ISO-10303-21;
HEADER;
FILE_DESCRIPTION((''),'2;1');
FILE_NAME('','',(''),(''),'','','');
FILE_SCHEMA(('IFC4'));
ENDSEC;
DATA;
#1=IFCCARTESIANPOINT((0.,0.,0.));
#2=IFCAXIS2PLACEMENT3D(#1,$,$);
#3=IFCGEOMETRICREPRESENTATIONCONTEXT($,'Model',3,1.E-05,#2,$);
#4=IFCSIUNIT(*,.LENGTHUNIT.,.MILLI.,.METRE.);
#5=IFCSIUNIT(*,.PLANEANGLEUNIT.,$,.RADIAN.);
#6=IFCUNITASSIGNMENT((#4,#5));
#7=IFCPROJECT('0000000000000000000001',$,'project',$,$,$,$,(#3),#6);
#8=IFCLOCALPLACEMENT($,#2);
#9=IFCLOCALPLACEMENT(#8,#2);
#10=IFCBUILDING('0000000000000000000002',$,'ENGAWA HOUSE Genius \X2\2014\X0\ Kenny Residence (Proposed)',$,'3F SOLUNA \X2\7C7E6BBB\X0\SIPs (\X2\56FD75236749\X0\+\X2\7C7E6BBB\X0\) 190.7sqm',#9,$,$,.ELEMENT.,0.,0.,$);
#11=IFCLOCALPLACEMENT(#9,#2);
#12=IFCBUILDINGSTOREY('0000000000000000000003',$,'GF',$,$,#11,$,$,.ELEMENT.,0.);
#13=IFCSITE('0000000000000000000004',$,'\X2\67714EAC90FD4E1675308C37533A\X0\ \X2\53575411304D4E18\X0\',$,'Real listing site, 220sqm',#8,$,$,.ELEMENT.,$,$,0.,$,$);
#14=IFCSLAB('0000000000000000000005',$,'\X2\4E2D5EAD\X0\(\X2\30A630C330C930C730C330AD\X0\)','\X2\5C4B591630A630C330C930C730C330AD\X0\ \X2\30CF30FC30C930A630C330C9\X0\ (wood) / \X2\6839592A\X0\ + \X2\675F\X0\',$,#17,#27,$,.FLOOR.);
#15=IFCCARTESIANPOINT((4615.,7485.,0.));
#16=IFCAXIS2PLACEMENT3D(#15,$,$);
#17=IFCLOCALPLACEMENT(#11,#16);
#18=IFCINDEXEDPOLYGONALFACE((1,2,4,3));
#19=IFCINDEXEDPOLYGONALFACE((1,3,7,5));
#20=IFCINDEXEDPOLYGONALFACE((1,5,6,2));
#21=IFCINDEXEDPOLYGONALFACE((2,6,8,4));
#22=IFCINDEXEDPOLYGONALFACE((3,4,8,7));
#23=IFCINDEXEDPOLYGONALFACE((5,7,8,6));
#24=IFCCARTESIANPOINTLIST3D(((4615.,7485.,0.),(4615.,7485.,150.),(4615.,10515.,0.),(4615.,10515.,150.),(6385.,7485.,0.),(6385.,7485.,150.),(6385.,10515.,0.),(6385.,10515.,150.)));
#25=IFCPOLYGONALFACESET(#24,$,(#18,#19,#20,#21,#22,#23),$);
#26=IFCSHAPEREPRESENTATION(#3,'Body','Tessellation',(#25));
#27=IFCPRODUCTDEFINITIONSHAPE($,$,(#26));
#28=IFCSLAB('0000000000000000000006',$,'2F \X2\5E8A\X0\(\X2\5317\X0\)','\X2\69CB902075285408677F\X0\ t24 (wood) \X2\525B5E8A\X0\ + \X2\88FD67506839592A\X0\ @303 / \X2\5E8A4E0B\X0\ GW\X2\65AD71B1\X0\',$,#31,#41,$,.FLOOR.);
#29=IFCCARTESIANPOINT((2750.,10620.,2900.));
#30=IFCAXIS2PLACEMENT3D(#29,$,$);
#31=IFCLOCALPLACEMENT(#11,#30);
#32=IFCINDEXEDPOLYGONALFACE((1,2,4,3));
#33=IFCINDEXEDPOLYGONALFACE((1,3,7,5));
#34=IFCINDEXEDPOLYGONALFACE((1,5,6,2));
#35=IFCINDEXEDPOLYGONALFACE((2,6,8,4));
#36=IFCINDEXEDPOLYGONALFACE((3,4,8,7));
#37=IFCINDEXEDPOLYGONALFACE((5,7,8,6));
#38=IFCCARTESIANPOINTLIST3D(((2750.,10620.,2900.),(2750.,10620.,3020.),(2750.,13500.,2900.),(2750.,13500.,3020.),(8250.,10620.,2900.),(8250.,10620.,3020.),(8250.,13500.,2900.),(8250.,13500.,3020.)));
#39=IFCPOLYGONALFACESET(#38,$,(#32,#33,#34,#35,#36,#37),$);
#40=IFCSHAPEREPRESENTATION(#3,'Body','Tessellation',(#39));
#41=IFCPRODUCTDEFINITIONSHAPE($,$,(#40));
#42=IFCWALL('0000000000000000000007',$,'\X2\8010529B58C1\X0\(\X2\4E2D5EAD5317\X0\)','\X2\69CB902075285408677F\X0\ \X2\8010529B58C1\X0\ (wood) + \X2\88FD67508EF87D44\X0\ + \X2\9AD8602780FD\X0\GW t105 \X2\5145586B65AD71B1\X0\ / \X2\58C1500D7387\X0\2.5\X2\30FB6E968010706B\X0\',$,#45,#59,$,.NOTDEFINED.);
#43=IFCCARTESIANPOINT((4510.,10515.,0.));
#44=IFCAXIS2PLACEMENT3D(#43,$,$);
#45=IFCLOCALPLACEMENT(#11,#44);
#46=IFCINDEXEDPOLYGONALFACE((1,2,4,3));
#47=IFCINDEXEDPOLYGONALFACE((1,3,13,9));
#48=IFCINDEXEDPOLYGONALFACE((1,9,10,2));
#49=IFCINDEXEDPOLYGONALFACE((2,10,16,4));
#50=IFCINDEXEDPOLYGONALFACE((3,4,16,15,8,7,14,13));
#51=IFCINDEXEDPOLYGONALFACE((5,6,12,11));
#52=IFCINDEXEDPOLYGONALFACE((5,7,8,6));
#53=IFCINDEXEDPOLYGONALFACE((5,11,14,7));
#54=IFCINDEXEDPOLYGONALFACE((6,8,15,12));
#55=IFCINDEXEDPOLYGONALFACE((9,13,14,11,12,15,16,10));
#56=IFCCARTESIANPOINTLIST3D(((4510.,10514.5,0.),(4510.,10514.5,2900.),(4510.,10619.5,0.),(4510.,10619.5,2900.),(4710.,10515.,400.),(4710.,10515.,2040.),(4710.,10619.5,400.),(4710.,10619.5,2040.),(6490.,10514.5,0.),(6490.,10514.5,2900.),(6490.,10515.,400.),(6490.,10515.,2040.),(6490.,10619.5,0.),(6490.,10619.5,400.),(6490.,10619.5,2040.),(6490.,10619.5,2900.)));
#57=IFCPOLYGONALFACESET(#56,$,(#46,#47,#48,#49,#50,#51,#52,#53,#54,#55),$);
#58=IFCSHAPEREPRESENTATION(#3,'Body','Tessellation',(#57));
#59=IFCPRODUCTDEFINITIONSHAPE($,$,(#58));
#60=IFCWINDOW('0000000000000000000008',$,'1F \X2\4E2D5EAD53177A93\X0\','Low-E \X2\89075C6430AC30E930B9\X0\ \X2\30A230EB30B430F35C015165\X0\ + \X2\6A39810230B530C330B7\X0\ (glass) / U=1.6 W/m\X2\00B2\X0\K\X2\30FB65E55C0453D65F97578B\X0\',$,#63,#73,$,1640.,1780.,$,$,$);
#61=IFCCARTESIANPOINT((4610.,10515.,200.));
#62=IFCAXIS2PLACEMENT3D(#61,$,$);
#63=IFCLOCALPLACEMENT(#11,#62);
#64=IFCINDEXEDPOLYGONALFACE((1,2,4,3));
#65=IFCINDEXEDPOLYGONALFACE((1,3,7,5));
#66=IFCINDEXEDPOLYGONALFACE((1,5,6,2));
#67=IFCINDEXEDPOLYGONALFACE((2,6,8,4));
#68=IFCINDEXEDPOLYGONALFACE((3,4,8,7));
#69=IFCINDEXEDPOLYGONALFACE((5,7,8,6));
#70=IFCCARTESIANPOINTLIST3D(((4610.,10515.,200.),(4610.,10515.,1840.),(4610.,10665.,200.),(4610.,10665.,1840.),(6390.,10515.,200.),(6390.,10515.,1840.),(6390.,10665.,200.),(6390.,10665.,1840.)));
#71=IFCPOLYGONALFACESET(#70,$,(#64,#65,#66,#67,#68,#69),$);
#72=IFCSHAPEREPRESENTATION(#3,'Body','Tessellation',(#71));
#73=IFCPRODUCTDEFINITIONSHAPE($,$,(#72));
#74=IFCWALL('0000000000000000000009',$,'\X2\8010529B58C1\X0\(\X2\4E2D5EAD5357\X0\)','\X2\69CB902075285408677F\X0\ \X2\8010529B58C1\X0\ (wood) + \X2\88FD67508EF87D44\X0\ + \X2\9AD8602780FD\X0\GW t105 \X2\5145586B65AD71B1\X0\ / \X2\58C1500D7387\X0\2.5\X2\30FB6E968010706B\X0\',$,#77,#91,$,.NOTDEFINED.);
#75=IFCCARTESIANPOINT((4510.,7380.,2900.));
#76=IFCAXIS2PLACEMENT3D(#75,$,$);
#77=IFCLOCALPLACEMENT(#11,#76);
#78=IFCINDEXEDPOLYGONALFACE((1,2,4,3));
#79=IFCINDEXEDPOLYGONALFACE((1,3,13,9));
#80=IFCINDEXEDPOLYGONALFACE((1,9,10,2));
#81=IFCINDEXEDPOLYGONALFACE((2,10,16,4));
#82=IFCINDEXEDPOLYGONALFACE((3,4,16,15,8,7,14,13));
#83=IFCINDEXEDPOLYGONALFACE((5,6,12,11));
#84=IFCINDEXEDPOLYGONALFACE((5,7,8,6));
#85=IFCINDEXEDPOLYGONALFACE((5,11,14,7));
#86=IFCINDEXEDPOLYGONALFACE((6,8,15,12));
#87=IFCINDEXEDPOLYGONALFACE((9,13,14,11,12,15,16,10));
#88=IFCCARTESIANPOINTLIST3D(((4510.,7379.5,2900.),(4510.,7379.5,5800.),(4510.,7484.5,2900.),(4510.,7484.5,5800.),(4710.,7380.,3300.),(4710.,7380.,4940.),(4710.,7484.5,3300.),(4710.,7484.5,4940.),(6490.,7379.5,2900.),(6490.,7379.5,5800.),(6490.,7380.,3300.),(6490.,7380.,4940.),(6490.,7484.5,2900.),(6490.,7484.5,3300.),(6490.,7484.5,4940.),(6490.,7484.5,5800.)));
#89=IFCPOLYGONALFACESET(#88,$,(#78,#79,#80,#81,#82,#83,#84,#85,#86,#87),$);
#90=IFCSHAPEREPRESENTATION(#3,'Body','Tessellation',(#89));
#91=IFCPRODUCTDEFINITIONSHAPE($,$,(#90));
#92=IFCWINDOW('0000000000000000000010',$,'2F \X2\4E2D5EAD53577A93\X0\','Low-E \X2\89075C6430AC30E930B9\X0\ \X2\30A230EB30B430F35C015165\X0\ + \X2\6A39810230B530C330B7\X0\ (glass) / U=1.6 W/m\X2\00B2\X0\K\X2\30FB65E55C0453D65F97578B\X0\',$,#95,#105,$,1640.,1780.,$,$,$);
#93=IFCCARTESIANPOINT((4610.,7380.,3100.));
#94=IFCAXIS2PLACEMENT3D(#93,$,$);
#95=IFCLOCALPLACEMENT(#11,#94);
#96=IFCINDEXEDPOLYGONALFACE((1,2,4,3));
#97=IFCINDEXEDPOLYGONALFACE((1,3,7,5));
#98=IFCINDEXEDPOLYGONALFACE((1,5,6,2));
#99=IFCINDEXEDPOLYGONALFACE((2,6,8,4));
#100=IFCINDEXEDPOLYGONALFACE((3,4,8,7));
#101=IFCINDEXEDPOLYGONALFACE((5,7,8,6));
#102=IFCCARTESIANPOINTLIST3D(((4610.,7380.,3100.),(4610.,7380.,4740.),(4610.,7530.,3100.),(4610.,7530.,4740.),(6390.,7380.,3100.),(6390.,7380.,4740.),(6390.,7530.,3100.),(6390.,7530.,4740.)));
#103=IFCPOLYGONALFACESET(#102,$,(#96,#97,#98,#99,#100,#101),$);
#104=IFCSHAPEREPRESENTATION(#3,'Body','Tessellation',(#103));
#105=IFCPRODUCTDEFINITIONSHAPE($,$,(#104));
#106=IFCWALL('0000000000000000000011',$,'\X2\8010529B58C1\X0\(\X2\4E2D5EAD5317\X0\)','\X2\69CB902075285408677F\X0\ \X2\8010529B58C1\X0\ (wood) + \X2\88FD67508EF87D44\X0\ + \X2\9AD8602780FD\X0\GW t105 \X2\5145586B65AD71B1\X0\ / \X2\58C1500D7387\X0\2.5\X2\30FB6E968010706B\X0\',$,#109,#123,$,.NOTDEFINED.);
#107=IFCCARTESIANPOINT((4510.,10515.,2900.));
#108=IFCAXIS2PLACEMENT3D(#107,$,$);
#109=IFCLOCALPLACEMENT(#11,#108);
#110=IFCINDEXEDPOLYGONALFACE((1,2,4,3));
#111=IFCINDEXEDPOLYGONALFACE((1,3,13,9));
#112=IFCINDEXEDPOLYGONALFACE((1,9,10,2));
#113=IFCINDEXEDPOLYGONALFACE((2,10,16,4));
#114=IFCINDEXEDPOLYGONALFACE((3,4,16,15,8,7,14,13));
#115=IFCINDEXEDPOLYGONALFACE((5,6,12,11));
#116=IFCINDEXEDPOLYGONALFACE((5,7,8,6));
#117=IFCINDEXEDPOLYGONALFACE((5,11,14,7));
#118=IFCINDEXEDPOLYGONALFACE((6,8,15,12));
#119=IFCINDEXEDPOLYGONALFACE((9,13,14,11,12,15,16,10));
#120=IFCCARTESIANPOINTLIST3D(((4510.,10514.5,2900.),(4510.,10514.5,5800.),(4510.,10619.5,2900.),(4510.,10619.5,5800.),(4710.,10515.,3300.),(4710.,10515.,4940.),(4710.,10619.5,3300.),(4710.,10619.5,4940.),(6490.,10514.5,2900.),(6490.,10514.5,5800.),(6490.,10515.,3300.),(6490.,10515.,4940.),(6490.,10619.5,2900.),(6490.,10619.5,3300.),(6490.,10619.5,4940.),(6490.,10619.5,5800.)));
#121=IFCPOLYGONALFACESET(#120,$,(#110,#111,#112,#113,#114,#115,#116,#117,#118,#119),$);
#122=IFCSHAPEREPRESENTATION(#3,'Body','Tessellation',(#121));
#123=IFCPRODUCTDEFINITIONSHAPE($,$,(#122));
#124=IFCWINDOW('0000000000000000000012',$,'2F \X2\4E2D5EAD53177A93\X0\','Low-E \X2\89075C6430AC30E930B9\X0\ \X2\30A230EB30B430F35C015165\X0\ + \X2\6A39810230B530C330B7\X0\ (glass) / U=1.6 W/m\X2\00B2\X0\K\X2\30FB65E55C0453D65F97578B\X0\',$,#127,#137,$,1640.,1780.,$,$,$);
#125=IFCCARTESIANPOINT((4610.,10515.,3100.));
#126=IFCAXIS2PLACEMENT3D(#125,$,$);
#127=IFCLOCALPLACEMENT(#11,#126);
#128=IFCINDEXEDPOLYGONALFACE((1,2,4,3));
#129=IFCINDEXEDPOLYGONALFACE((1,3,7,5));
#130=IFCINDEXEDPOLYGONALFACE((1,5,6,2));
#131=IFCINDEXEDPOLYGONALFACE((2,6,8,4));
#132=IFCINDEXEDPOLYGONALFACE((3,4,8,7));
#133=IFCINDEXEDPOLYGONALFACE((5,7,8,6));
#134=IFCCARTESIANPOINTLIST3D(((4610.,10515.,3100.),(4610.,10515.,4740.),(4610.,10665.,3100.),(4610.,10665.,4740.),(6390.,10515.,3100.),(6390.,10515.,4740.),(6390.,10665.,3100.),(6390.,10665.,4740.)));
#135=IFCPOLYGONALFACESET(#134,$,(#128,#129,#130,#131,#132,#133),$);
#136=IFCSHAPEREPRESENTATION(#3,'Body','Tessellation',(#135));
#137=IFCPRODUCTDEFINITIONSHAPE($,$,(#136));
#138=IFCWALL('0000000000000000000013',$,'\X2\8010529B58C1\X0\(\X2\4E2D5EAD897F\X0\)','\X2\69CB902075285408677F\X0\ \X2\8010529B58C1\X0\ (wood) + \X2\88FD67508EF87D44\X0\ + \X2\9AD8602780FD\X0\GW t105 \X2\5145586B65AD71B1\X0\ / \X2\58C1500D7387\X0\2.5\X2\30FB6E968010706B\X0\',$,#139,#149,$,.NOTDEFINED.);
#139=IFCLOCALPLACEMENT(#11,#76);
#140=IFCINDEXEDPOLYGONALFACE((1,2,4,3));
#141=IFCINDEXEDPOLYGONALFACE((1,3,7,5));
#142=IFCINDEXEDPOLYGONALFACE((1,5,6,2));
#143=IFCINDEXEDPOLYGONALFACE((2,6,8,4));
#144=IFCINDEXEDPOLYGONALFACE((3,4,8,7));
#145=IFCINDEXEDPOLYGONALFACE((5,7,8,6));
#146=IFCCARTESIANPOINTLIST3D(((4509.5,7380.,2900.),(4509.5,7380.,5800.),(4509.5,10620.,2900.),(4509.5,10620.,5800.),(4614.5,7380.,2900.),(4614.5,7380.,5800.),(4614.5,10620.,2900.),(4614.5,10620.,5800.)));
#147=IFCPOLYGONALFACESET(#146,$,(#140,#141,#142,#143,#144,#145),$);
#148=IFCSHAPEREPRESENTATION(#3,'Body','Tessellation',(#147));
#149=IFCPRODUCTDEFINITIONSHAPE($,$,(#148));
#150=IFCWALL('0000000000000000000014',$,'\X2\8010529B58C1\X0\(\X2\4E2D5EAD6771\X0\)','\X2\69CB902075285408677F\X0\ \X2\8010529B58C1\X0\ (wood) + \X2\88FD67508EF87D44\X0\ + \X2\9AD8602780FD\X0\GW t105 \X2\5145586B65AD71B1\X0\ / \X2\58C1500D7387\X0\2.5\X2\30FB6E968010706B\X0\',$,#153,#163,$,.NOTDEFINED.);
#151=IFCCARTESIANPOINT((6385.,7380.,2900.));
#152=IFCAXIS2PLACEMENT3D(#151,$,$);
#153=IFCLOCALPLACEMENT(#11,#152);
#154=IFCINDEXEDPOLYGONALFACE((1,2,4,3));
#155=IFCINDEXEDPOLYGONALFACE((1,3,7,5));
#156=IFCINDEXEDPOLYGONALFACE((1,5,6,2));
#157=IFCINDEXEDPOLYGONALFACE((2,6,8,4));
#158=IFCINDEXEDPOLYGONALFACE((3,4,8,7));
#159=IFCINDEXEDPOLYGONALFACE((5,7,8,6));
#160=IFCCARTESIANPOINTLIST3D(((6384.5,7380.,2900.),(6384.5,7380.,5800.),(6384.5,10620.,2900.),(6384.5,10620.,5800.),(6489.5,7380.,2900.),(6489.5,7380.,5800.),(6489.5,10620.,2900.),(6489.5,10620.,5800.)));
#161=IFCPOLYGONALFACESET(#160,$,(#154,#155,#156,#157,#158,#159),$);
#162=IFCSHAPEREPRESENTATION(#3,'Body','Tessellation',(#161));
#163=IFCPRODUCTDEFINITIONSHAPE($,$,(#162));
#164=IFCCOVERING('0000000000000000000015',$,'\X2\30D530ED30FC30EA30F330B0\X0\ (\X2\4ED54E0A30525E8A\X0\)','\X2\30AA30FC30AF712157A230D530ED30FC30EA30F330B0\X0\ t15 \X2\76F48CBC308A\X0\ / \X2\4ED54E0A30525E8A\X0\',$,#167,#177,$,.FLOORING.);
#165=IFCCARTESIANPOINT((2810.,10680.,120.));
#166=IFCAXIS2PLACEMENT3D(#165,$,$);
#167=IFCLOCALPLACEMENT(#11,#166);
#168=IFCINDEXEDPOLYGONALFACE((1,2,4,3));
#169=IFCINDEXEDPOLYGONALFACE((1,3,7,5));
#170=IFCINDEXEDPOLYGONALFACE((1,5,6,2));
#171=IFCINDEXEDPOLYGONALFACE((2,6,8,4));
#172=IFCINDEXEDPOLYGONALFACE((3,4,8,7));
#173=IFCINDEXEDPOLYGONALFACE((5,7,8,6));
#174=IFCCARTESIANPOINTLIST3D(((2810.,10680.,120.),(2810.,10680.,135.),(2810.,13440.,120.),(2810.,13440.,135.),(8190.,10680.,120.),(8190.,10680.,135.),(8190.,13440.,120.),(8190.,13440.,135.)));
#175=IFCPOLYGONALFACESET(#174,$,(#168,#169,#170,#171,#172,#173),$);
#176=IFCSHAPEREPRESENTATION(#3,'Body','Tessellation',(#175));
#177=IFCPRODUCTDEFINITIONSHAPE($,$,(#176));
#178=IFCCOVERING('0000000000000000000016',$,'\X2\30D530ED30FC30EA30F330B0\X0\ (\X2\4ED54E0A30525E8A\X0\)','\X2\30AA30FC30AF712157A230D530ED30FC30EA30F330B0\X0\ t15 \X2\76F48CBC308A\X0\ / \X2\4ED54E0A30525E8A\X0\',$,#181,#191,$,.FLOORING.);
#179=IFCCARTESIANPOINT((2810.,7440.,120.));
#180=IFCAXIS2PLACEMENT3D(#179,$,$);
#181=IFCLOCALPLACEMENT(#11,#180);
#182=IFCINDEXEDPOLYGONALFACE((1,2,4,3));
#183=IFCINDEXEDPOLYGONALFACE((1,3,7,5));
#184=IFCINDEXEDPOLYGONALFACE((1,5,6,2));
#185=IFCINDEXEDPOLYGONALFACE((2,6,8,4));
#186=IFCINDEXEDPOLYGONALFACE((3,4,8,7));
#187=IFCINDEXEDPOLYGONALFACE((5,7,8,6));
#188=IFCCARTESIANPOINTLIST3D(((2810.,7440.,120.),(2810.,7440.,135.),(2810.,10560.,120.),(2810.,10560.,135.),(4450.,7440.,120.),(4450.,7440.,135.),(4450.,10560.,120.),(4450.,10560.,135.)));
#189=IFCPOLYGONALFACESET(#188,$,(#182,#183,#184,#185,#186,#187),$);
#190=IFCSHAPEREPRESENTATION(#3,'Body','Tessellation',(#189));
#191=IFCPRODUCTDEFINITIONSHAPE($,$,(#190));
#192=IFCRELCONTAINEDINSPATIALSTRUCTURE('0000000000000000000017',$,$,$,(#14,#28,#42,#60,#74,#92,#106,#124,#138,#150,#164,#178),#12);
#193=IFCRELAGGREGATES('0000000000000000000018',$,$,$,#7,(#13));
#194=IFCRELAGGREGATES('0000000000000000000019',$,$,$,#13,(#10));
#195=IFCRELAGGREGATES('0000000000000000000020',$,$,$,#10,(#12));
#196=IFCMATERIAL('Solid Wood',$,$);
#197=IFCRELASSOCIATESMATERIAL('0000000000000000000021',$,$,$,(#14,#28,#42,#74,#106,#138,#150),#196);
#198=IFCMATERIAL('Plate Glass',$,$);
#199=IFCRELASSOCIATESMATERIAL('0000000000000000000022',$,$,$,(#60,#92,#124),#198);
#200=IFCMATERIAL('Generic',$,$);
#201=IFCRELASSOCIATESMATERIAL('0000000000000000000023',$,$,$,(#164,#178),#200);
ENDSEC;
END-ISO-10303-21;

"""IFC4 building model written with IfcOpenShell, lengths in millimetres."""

from ifc_helpers import new_model, si_unit, frame, frame_2d, origin, place, context, project, spatial, rectangle, extrude, material, element, fill, save


model = new_model("IFC4")

# Units and contexts
model_context = context("Model", 3, precision=1e-05, world=origin())
ifc_project = project(units=[si_unit("LENGTHUNIT", "METRE", prefix="MILLI"), si_unit("PLANEANGLEUNIT", "RADIAN")], contexts=[model_context])

# Site, building, storey
site_placement = place(None, origin())
site = spatial("IfcSite", under=ifc_project, at=site_placement, Name="東京都世田谷区 南向き丘", ObjectType="Real listing site, 220sqm", CompositionType="ELEMENT", RefElevation=0.0)
building_placement = place(site_placement, origin())
building = spatial("IfcBuilding", under=site, at=building_placement, Name="ENGAWA HOUSE Genius — Kenny Residence (Proposed)", ObjectType="3F SOLUNA 籾殻SIPs (国産杉+籾殻) 190.7sqm", CompositionType="ELEMENT", ElevationOfRefHeight=0.0, ElevationOfTerrain=0.0)
storey_placement = place(building_placement, origin())
storey = spatial("IfcBuildingStorey", under=building, at=storey_placement, Name="GF", CompositionType="ELEMENT", Elevation=0.0)

# Slabs
ifc_material_1 = material(Name="Solid Wood")
slab_1_placement = place(storey_placement, frame((4615.0, 7485.0, 0.0)))
element("IfcSlab", 1, at=slab_1_placement, inside=storey, material=ifc_material_1, Name="中庭(ウッドデッキ)", Description="屋外ウッドデッキ ハードウッド (wood) / 根太 + 束", PredefinedType="FLOOR", context=model_context, shape_type="SweptSolid", body=[
    extrude(rectangle(XDim=1770.0, YDim=3030.0, at=frame_2d((885.0, 1515.0))), frame((4615.0, 7485.0, 0.0)), (0.0, 0.0, 1.0), 150.0),
])
slab_2_placement = place(storey_placement, frame((2750.0, 10620.0, 2900.0)))
element("IfcSlab", 2, at=slab_2_placement, inside=storey, material=ifc_material_1, Name="2F 床(北)", Description="構造用合板 t24 (wood) 剛床 + 製材根太 @303 / 床下 GW断熱", PredefinedType="FLOOR", context=model_context, shape_type="SweptSolid", body=[
    extrude(rectangle(XDim=5500.0, YDim=2880.0, at=frame_2d((2750.0, 1440.0))), frame((2750.0, 10620.0, 2900.0)), (0.0, 0.0, 1.0), 120.0),
])

# Wall, opening, window
wall_1_placement = place(storey_placement, frame((4510.0, 10515.0, 0.0)))
wall_1 = element("IfcWall", 3, at=wall_1_placement, inside=storey, material=ifc_material_1, Name="耐力壁(中庭北)", Description="構造用合板 耐力壁 (wood) + 製材軸組 + 高性能GW t105 充填断熱 / 壁倍率2.5・準耐火", PredefinedType="NOTDEFINED", context=model_context, shape_type="SweptSolid", body=[
    extrude(rectangle(XDim=1980.0, YDim=105.0, at=frame_2d((990.0, 52.0))), frame((4510.0, 10515.0, 0.0)), (0.0, 0.0, 1.0), 2900.0),
])
opening_1_placement = place(storey_placement, frame((4610.0, 10515.0, 200.0)))
opening_1 = element("IfcOpeningElement", 4, at=opening_1_placement, cuts=wall_1, PredefinedType="NOTDEFINED", context=model_context, shape_type="SweptSolid", body=[
    extrude(rectangle(XDim=1780.0, YDim=150.0, at=frame_2d((890.0, 75.0))), frame((4610.0, 10515.0, 200.0)), (0.0, 0.0, 1.0), 1640.0),
])
ifc_material_2 = material(Name="Plate Glass")
window_1_placement = place(storey_placement, frame((4610.0, 10515.0, 200.0)))
window_1 = element("IfcWindow", 5, at=window_1_placement, inside=storey, material=ifc_material_2, Name="1F 中庭北窓", Description="Low-E 複層ガラス アルゴン封入 + 樹脂サッシ (glass) / U=1.6 W/m²K・日射取得型", OverallHeight=1640.0, OverallWidth=1780.0, context=model_context, shape_type="SweptSolid", body=[
    extrude(rectangle(XDim=1780.0, YDim=150.0, at=frame_2d((890.0, 75.0))), frame((4610.0, 10515.0, 200.0)), (0.0, 0.0, 1.0), 1640.0),
])
fill(opening_1, window_1)

# Walls, openings, windows
wall_2_placement = place(storey_placement, frame((4510.0, 7380.0, 2900.0)))
wall_2 = element("IfcWall", 6, at=wall_2_placement, inside=storey, material=ifc_material_1, Name="耐力壁(中庭南)", Description="構造用合板 耐力壁 (wood) + 製材軸組 + 高性能GW t105 充填断熱 / 壁倍率2.5・準耐火", PredefinedType="NOTDEFINED", context=model_context, shape_type="SweptSolid", body=[
    extrude(rectangle(XDim=1980.0, YDim=105.0, at=frame_2d((990.0, 52.0))), frame((4510.0, 7380.0, 2900.0)), (0.0, 0.0, 1.0), 2900.0),
])
opening_2_placement = place(storey_placement, frame((4610.0, 7380.0, 3100.0)))
opening_2 = element("IfcOpeningElement", 7, at=opening_2_placement, cuts=wall_2, PredefinedType="NOTDEFINED", context=model_context, shape_type="SweptSolid", body=[
    extrude(rectangle(XDim=1780.0, YDim=150.0, at=frame_2d((890.0, 75.0))), frame((4610.0, 7380.0, 3100.0)), (0.0, 0.0, 1.0), 1640.0),
])
window_2_placement = place(storey_placement, frame((4610.0, 7380.0, 3100.0)))
window_2 = element("IfcWindow", 8, at=window_2_placement, inside=storey, material=ifc_material_2, Name="2F 中庭南窓", Description="Low-E 複層ガラス アルゴン封入 + 樹脂サッシ (glass) / U=1.6 W/m²K・日射取得型", OverallHeight=1640.0, OverallWidth=1780.0, context=model_context, shape_type="SweptSolid", body=[
    extrude(rectangle(XDim=1780.0, YDim=150.0, at=frame_2d((890.0, 75.0))), frame((4610.0, 7380.0, 3100.0)), (0.0, 0.0, 1.0), 1640.0),
])
fill(opening_2, window_2)
wall_3_placement = place(storey_placement, frame((4510.0, 10515.0, 2900.0)))
wall_3 = element("IfcWall", 9, at=wall_3_placement, inside=storey, material=ifc_material_1, Name="耐力壁(中庭北)", Description="構造用合板 耐力壁 (wood) + 製材軸組 + 高性能GW t105 充填断熱 / 壁倍率2.5・準耐火", PredefinedType="NOTDEFINED", context=model_context, shape_type="SweptSolid", body=[
    extrude(rectangle(XDim=1980.0, YDim=105.0, at=frame_2d((990.0, 52.0))), frame((4510.0, 10515.0, 2900.0)), (0.0, 0.0, 1.0), 2900.0),
])
opening_3_placement = place(storey_placement, frame((4610.0, 10515.0, 3100.0)))
opening_3 = element("IfcOpeningElement", 10, at=opening_3_placement, cuts=wall_3, PredefinedType="NOTDEFINED", context=model_context, shape_type="SweptSolid", body=[
    extrude(rectangle(XDim=1780.0, YDim=150.0, at=frame_2d((890.0, 75.0))), frame((4610.0, 10515.0, 3100.0)), (0.0, 0.0, 1.0), 1640.0),
])
window_3_placement = place(storey_placement, frame((4610.0, 10515.0, 3100.0)))
window_3 = element("IfcWindow", 11, at=window_3_placement, inside=storey, material=ifc_material_2, Name="2F 中庭北窓", Description="Low-E 複層ガラス アルゴン封入 + 樹脂サッシ (glass) / U=1.6 W/m²K・日射取得型", OverallHeight=1640.0, OverallWidth=1780.0, context=model_context, shape_type="SweptSolid", body=[
    extrude(rectangle(XDim=1780.0, YDim=150.0, at=frame_2d((890.0, 75.0))), frame((4610.0, 10515.0, 3100.0)), (0.0, 0.0, 1.0), 1640.0),
])
fill(opening_3, window_3)

# Walls
wall_4_placement = place(storey_placement, frame((4510.0, 7380.0, 2900.0)))
element("IfcWall", 12, at=wall_4_placement, inside=storey, material=ifc_material_1, Name="耐力壁(中庭西)", Description="構造用合板 耐力壁 (wood) + 製材軸組 + 高性能GW t105 充填断熱 / 壁倍率2.5・準耐火", PredefinedType="NOTDEFINED", context=model_context, shape_type="SweptSolid", body=[
    extrude(rectangle(XDim=105.0, YDim=3240.0, at=frame_2d((52.0, 1620.0))), frame((4510.0, 7380.0, 2900.0)), (0.0, 0.0, 1.0), 2900.0),
])
wall_5_placement = place(storey_placement, frame((6385.0, 7380.0, 2900.0)))
element("IfcWall", 13, at=wall_5_placement, inside=storey, material=ifc_material_1, Name="耐力壁(中庭東)", Description="構造用合板 耐力壁 (wood) + 製材軸組 + 高性能GW t105 充填断熱 / 壁倍率2.5・準耐火", PredefinedType="NOTDEFINED", context=model_context, shape_type="SweptSolid", body=[
    extrude(rectangle(XDim=105.0, YDim=3240.0, at=frame_2d((52.0, 1620.0))), frame((6385.0, 7380.0, 2900.0)), (0.0, 0.0, 1.0), 2900.0),
])

# Coverings
ifc_material_3 = material(Name="Generic")
covering_1_placement = place(storey_placement, frame((2810.0, 10680.0, 120.0)))
element("IfcCovering", 14, at=covering_1_placement, inside=storey, material=ifc_material_3, Name="フローリング (仕上げ床)", Description="オーク無垢フローリング t15 直貼り / 仕上げ床", PredefinedType="FLOORING", context=model_context, shape_type="SweptSolid", body=[
    extrude(rectangle(XDim=5380.0, YDim=2760.0, at=frame_2d((2690.0, 1380.0))), frame((2810.0, 10680.0, 120.0)), (0.0, 0.0, 1.0), 15.0),
])
covering_2_placement = place(storey_placement, frame((2810.0, 7440.0, 120.0)))
element("IfcCovering", 15, at=covering_2_placement, inside=storey, material=ifc_material_3, Name="フローリング (仕上げ床)", Description="オーク無垢フローリング t15 直貼り / 仕上げ床", PredefinedType="FLOORING", context=model_context, shape_type="SweptSolid", body=[
    extrude(rectangle(XDim=1640.0, YDim=3120.0, at=frame_2d((820.0, 1560.0))), frame((2810.0, 7440.0, 120.0)), (0.0, 0.0, 1.0), 15.0),
])

save(model, "model.ifc")
